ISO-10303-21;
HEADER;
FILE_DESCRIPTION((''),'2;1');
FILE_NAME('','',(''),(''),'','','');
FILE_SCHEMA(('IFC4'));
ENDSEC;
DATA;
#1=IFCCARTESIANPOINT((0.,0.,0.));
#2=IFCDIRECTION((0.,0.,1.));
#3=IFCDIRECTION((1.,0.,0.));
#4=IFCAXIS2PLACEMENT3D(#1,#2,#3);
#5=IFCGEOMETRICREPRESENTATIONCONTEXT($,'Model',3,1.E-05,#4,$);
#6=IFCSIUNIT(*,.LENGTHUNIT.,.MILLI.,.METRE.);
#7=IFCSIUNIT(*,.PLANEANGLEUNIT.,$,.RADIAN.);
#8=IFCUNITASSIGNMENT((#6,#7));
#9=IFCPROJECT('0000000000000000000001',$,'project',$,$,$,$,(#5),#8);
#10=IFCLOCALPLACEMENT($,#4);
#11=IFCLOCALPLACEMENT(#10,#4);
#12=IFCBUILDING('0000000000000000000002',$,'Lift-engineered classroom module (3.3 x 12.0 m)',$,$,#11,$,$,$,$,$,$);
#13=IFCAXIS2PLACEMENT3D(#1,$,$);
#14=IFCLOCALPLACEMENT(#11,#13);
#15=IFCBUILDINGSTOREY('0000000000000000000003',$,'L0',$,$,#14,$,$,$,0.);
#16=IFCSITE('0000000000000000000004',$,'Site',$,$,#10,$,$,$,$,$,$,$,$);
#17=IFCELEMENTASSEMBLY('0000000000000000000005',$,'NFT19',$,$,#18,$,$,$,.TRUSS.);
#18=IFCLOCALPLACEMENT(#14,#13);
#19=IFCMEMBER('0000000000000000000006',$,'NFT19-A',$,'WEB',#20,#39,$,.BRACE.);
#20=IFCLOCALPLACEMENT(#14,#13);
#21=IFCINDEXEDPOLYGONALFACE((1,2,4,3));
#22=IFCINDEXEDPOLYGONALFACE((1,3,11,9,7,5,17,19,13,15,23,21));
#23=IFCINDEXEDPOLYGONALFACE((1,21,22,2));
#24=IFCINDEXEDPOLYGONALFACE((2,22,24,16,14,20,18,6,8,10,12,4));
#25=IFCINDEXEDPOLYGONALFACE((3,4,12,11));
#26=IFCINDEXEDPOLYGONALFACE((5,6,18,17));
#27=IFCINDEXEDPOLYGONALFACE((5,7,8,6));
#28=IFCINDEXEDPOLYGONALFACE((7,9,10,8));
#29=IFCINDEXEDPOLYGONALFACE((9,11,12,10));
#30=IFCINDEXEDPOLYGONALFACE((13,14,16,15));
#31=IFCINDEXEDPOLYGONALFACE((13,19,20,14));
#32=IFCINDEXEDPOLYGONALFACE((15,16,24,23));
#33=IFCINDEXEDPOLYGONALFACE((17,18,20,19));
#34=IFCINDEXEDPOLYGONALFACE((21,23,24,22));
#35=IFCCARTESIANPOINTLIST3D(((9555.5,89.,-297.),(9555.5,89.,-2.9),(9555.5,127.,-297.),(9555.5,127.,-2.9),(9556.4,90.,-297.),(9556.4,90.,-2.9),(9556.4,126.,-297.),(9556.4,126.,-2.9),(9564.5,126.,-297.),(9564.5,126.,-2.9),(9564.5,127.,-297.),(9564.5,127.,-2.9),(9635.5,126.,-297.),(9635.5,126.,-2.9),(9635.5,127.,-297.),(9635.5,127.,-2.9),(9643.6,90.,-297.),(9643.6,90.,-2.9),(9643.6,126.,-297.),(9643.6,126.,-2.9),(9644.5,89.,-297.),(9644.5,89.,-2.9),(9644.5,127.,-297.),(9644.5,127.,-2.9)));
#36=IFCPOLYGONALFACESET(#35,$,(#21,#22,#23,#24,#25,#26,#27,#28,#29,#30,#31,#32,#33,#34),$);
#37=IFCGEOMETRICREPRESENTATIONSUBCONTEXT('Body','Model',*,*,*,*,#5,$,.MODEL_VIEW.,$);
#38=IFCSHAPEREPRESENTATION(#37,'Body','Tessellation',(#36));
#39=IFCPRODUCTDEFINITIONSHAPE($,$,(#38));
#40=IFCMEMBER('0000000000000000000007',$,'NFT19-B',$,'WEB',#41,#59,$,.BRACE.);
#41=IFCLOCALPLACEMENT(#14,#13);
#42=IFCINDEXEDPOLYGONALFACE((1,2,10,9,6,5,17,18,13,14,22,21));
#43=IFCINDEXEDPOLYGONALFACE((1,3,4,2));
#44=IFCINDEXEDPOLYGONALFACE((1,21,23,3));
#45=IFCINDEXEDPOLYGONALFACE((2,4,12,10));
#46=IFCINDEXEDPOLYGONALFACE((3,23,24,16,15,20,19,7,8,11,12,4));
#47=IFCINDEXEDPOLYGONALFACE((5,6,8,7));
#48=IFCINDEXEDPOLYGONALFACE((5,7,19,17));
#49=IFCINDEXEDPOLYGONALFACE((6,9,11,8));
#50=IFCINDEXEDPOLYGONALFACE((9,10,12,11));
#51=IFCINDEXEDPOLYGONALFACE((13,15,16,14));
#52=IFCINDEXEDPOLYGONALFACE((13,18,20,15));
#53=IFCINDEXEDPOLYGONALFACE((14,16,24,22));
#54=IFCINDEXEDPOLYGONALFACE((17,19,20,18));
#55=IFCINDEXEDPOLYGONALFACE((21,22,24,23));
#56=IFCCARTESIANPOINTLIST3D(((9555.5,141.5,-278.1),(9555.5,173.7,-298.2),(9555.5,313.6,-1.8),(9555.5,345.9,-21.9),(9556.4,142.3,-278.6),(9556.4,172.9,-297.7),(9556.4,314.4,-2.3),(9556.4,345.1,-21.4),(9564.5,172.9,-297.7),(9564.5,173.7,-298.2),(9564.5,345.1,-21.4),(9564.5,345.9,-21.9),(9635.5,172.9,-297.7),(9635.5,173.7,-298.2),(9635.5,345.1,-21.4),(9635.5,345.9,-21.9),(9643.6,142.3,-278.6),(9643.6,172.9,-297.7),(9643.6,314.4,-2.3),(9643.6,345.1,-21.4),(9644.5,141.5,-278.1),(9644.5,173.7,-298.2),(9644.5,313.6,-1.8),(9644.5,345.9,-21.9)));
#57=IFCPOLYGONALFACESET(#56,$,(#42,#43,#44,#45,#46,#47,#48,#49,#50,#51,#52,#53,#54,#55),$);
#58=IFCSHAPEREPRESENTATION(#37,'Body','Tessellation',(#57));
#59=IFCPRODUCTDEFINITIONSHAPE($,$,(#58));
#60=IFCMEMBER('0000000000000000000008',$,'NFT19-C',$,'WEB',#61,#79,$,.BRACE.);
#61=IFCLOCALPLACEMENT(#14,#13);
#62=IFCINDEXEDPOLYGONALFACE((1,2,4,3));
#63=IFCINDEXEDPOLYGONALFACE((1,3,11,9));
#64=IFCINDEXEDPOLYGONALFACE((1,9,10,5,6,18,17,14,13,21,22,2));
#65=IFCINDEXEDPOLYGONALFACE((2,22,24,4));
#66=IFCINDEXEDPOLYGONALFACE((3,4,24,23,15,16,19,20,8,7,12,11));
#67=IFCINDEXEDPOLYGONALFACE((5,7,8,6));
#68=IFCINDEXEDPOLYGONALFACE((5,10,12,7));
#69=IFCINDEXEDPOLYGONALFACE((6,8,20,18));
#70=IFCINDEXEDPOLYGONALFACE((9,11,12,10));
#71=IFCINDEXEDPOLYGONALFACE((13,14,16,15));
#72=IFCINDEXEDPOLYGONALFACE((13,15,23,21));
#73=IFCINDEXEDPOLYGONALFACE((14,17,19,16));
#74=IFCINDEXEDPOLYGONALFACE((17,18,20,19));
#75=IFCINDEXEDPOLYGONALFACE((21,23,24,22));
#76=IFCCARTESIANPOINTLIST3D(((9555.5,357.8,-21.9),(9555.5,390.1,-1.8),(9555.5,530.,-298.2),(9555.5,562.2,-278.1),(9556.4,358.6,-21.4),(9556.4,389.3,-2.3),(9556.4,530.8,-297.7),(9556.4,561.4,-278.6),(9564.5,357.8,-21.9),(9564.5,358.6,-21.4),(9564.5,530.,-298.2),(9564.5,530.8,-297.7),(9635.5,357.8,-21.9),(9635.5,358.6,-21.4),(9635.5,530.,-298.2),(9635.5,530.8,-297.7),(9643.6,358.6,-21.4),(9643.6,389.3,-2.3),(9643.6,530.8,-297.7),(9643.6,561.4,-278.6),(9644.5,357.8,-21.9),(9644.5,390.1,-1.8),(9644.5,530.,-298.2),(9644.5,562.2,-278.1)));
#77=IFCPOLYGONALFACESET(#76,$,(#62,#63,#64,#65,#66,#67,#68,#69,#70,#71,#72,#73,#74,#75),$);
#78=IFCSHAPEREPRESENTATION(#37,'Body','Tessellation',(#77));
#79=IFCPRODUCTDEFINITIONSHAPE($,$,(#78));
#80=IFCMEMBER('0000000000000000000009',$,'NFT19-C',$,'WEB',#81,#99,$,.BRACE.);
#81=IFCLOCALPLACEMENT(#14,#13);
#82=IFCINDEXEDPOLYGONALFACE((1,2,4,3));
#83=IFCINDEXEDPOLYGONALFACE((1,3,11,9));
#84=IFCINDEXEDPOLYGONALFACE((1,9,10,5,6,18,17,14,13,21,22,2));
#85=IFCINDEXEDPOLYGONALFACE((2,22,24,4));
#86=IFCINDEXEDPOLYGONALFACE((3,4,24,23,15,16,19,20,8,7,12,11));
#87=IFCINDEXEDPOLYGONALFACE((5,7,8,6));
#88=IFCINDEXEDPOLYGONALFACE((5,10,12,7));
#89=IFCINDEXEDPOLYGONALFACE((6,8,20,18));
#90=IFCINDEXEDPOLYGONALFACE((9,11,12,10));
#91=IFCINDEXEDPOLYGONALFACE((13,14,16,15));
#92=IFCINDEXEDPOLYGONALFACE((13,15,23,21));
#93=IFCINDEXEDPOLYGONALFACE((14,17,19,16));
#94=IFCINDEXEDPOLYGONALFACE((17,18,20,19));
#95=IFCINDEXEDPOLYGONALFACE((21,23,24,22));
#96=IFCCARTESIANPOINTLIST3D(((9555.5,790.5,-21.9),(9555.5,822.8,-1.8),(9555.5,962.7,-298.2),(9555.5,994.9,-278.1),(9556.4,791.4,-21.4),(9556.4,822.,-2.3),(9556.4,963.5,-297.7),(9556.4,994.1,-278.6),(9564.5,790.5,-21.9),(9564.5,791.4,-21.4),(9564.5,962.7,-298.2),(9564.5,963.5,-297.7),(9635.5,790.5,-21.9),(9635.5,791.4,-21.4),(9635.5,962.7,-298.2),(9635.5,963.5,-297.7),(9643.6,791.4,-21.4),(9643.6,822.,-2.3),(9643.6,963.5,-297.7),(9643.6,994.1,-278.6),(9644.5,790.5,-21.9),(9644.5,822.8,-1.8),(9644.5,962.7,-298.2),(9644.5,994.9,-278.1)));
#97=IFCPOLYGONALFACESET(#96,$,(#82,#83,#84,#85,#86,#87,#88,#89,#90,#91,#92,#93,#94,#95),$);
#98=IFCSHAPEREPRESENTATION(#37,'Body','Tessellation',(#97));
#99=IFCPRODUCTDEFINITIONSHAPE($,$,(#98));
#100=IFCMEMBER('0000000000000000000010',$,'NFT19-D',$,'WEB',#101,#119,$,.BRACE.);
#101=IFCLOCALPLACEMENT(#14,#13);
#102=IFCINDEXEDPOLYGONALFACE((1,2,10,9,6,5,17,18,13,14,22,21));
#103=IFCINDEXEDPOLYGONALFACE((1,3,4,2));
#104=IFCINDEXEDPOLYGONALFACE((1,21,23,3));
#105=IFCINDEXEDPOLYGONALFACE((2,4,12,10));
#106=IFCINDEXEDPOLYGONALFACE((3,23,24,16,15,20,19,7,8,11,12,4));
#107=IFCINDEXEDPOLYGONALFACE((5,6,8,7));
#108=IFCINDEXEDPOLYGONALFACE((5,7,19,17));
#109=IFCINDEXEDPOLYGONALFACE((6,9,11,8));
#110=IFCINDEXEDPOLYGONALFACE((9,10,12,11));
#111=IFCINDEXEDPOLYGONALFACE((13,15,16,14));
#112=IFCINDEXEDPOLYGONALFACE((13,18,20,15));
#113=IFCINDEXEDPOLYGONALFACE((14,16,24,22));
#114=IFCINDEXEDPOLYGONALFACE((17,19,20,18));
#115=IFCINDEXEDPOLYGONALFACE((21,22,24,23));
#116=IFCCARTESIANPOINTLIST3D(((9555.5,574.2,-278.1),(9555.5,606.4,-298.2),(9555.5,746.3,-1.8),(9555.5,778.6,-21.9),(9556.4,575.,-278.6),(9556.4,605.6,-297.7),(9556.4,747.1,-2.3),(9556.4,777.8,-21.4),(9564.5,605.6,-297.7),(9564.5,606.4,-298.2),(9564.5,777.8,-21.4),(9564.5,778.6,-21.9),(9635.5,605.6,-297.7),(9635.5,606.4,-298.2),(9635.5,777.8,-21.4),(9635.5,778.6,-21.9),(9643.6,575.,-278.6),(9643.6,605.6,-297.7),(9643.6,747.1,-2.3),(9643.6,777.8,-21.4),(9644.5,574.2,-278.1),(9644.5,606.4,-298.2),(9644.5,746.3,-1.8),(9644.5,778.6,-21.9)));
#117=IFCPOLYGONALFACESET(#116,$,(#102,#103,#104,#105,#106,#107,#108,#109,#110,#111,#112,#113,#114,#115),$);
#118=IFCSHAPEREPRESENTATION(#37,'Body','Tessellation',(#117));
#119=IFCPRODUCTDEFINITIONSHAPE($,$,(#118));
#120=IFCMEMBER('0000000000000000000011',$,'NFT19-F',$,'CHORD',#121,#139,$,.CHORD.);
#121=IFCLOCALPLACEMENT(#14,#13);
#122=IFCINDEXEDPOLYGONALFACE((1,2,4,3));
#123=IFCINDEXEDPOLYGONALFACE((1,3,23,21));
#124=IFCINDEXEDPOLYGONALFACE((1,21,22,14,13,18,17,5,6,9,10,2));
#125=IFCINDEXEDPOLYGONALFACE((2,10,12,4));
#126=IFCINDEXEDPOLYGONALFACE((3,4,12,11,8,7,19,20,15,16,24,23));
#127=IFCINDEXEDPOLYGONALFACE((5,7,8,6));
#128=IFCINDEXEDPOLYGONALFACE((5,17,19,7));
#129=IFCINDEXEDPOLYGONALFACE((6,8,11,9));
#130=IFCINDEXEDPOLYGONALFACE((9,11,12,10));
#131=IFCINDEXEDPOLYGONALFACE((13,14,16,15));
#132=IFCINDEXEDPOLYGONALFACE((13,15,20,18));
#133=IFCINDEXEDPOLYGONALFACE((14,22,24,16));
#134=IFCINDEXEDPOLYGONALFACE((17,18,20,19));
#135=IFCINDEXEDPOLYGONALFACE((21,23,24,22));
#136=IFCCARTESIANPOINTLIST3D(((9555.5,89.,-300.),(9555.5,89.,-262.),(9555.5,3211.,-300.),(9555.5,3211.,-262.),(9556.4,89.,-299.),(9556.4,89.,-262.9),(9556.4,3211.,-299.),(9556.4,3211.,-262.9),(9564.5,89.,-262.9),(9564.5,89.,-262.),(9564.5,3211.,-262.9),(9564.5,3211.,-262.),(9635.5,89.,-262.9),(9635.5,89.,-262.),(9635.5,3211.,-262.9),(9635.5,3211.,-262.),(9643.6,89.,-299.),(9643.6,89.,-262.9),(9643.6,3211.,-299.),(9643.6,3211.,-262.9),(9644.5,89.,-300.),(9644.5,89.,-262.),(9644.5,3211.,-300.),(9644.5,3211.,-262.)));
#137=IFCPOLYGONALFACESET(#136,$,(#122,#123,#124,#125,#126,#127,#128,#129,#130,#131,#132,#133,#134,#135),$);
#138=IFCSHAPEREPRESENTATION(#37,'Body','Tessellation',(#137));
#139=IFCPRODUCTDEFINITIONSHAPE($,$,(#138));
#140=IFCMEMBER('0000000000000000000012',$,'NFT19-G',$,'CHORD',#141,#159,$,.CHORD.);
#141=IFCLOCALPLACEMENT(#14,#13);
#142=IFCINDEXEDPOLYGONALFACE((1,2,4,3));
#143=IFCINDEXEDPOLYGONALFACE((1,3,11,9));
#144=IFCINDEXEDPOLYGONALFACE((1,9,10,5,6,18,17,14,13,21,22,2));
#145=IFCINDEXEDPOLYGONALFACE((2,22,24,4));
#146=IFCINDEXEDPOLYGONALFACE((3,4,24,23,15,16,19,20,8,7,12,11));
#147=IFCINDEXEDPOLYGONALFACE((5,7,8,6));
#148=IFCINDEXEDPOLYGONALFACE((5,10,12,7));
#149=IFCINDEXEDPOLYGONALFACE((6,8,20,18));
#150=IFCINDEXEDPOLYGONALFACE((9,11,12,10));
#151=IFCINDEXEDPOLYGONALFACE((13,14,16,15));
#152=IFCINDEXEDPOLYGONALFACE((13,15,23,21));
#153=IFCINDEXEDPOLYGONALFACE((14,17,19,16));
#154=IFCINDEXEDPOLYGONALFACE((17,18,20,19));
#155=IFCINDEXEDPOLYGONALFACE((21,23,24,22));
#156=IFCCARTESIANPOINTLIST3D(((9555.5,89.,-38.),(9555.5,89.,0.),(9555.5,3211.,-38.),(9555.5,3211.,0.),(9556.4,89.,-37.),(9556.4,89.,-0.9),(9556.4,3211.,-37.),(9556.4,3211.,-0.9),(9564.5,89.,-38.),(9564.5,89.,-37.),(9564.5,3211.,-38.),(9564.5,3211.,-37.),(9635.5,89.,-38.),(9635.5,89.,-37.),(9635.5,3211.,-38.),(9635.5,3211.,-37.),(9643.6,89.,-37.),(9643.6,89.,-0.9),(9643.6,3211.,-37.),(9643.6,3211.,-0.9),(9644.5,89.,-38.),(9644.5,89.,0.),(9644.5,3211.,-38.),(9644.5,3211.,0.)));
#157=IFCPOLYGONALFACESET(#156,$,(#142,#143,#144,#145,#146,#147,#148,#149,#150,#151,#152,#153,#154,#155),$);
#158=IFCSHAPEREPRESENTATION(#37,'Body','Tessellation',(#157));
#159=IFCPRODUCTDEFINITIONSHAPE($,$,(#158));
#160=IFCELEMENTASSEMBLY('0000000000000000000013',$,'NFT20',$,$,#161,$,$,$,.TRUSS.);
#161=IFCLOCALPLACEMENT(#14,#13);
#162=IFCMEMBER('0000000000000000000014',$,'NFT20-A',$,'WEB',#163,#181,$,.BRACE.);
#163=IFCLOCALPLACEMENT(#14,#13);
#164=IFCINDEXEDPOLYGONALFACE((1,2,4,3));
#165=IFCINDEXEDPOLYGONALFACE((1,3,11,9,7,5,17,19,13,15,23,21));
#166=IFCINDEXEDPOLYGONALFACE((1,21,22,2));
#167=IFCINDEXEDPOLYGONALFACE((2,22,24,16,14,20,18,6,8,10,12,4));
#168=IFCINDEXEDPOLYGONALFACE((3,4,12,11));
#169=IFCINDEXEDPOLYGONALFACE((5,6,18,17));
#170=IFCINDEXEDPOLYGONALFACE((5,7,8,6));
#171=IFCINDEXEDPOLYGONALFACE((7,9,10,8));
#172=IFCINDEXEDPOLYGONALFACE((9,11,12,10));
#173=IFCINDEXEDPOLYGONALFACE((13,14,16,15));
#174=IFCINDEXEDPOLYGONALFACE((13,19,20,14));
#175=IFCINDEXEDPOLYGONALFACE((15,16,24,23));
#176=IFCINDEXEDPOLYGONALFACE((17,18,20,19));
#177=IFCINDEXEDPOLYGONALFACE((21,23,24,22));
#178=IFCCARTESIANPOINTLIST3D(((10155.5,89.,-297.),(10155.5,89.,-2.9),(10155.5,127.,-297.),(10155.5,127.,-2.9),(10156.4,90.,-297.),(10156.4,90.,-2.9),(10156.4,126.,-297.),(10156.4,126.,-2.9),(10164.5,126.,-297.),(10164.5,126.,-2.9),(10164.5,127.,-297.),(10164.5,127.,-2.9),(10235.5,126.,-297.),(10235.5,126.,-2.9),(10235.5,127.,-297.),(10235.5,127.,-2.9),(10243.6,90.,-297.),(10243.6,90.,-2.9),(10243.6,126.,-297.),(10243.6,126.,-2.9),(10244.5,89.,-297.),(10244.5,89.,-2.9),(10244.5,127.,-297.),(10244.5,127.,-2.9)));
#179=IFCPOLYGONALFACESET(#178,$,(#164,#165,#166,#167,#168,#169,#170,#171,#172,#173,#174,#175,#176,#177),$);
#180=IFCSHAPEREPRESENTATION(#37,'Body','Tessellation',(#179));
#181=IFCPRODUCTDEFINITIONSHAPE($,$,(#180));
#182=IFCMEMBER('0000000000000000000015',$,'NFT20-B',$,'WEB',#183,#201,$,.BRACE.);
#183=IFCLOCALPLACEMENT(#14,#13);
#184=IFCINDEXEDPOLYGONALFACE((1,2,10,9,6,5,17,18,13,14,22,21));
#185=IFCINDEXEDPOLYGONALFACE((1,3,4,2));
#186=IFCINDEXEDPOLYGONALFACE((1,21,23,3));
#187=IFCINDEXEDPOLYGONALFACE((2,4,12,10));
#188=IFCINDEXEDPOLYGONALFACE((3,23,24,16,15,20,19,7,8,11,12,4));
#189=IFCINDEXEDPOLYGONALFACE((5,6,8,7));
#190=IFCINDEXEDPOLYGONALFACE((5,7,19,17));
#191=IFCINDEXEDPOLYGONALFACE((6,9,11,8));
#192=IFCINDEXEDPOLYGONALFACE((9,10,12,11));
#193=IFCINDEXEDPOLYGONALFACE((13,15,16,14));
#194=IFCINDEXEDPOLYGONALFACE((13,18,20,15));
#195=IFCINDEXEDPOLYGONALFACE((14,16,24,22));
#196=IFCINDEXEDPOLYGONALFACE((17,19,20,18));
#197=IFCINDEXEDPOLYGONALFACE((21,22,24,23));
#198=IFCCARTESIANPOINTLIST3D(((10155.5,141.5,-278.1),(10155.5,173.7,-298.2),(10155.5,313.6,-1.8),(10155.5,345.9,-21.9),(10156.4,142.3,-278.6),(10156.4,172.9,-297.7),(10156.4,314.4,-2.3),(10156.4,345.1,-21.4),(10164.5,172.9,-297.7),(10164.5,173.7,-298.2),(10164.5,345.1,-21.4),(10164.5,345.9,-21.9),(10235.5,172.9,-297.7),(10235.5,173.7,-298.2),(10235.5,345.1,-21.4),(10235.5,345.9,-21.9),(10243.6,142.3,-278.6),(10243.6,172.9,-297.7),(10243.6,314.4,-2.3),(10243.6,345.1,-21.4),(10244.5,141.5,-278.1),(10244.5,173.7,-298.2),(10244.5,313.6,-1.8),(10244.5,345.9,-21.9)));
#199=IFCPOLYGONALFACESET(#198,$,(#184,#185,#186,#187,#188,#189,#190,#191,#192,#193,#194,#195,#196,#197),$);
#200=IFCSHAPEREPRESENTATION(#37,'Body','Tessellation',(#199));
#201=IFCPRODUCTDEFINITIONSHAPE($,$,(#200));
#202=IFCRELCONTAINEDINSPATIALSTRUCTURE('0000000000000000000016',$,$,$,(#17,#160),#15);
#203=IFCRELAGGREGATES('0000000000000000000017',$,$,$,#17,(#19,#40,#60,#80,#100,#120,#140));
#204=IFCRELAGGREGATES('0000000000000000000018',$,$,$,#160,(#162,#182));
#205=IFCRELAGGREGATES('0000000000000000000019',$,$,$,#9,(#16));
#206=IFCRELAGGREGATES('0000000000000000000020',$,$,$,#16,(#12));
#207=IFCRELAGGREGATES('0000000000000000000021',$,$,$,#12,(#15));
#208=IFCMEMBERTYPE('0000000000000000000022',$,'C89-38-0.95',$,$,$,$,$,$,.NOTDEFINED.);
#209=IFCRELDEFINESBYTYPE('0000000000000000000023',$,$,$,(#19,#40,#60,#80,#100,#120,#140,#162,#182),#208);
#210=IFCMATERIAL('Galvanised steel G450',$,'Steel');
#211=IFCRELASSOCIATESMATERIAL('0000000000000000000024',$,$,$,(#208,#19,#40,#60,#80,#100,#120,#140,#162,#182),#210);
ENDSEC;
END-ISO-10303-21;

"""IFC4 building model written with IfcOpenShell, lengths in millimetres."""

from ifc_helpers import new_model, si_unit, frame, origin, origin_with_axes, origin_2d, place, context, subcontext, project, spatial, c_section, extrude, material, material_profile, profile_set, profile_usage, type_object, element, aggregate, save


model = new_model("IFC4")

# Units and contexts
model_context = context("Model", 3, precision=1e-05, world=origin_with_axes())
body_context = subcontext(model_context, "Body", "Model", "MODEL_VIEW")
ifc_project = project(units=[si_unit("LENGTHUNIT", "METRE", prefix="MILLI"), si_unit("PLANEANGLEUNIT", "RADIAN")], contexts=[model_context])

# Site, building, storey
site_placement = place(None, origin_with_axes())
site = spatial("IfcSite", under=ifc_project, at=site_placement, Name="Site")
building_placement = place(site_placement, origin_with_axes())
building = spatial("IfcBuilding", under=site, at=building_placement, Name="Lift-engineered classroom module (3.3 x 12.0 m)")
storey_placement = place(building_placement, origin())
storey = spatial("IfcBuildingStorey", under=building, at=storey_placement, Name="L0", Elevation=0.0)

# Element assemblies, members
assembly_1_placement = place(storey_placement, frame((9600.0, 89.0, -300.0)))
assembly_1 = element("IfcElementAssembly", 1, at=assembly_1_placement, inside=storey, Name="NFT19", PredefinedType="TRUSS")
ifc_material = material(Name="Galvanised steel G450", Category="Steel")
ifc_material_profile_1 = material_profile(ifc_material, c_section(Depth=89.0, Width=38.0, WallThickness=0.9, Girth=9.0, at=origin_2d()), Name="C89-38-0.95")
ifc_profile_set_1 = profile_set([ifc_material_profile_1], Name="C89-38-0.95")
ifc_profile_usage_1 = profile_usage(ifc_profile_set_1)
member_type_1 = type_object("IfcMemberType", Name="C89-38-0.95", PredefinedType="NOTDEFINED", material=ifc_profile_set_1)
member_1_placement = place(assembly_1_placement, frame((0.0, 19.0, 2.9), z_axis=(0.0, 0.0, 1.0), x_axis=(0.0, 1.0, 0.0)))
member_1 = element("IfcMember", 2, at=member_1_placement, type_object=member_type_1, material=ifc_profile_usage_1, Name="NFT19-A", ObjectType="WEB", PredefinedType="BRACE", context=body_context, shape_type="SweptSolid", body=[
    extrude(c_section(Depth=89.0, Width=38.0, WallThickness=0.9, Girth=9.0, at=origin_2d()), origin(), (0.0, 0.0, 1.0), 294.1),
])
member_2_placement = place(assembly_1_placement, frame((0.0, 68.6, 11.8), z_axis=(0.0, 0.528797, 0.848748), x_axis=(0.0, 0.848748, -0.528797)))
member_2 = element("IfcMember", 3, at=member_2_placement, type_object=member_type_1, material=ifc_profile_usage_1, Name="NFT19-B", ObjectType="WEB", PredefinedType="BRACE", context=body_context, shape_type="SweptSolid", body=[
    extrude(c_section(Depth=89.0, Width=38.0, WallThickness=0.9, Girth=9.0, at=origin_2d()), origin(), (0.0, 0.0, 1.0), 325.6),
])
member_3_placement = place(assembly_1_placement, frame((0.0, 457.1, 11.8), z_axis=(0.0, -0.528797, 0.848748), x_axis=(0.0, -0.848748, -0.528797)))
member_3 = element("IfcMember", 4, at=member_3_placement, type_object=member_type_1, material=ifc_profile_usage_1, Name="NFT19-C", ObjectType="WEB", PredefinedType="BRACE", context=body_context, shape_type="SweptSolid", body=[
    extrude(c_section(Depth=89.0, Width=38.0, WallThickness=0.9, Girth=9.0, at=origin_2d()), origin(), (0.0, 0.0, 1.0), 325.6),
])
member_4_placement = place(assembly_1_placement, frame((0.0, 889.8, 11.8), z_axis=(0.0, -0.528797, 0.848748), x_axis=(0.0, -0.848748, -0.528797)))
member_4 = element("IfcMember", 5, at=member_4_placement, type_object=member_type_1, material=ifc_profile_usage_1, Name="NFT19-C", ObjectType="WEB", PredefinedType="BRACE", context=body_context, shape_type="SweptSolid", body=[
    extrude(c_section(Depth=89.0, Width=38.0, WallThickness=0.9, Girth=9.0, at=origin_2d()), origin(), (0.0, 0.0, 1.0), 325.6),
])
member_5_placement = place(assembly_1_placement, frame((0.0, 501.3, 11.8), z_axis=(0.0, 0.528775, 0.848762), x_axis=(0.0, 0.848762, -0.528775)))
member_5 = element("IfcMember", 6, at=member_5_placement, type_object=member_type_1, material=ifc_profile_usage_1, Name="NFT19-D", ObjectType="WEB", PredefinedType="BRACE", context=body_context, shape_type="SweptSolid", body=[
    extrude(c_section(Depth=89.0, Width=38.0, WallThickness=0.9, Girth=9.0, at=origin_2d()), origin(), (0.0, 0.0, 1.0), 325.6),
])
member_6_placement = place(assembly_1_placement, frame((0.0, 0.0, 19.0), z_axis=(0.0, 1.0, 0.0), x_axis=(0.0, 0.0, 1.0)))
member_6 = element("IfcMember", 7, at=member_6_placement, type_object=member_type_1, material=ifc_profile_usage_1, Name="NFT19-F", ObjectType="CHORD", PredefinedType="CHORD", context=body_context, shape_type="SweptSolid", body=[
    extrude(c_section(Depth=89.0, Width=38.0, WallThickness=0.9, Girth=9.0, at=origin_2d()), origin(), (0.0, 0.0, 1.0), 3122.0),
])
member_7_placement = place(assembly_1_placement, frame((0.0, 0.0, 281.0), z_axis=(0.0, 1.0, 0.0), x_axis=(0.0, 0.0, -1.0)))
member_7 = element("IfcMember", 8, at=member_7_placement, type_object=member_type_1, material=ifc_profile_usage_1, Name="NFT19-G", ObjectType="CHORD", PredefinedType="CHORD", context=body_context, shape_type="SweptSolid", body=[
    extrude(c_section(Depth=89.0, Width=38.0, WallThickness=0.9, Girth=9.0, at=origin_2d()), origin(), (0.0, 0.0, 1.0), 3122.0),
])
aggregate(assembly_1, [member_1, member_2, member_3, member_4, member_5, member_6, member_7])
assembly_2_placement = place(storey_placement, frame((10200.0, 89.0, -300.0)))
assembly_2 = element("IfcElementAssembly", 9, at=assembly_2_placement, inside=storey, Name="NFT20", PredefinedType="TRUSS")
member_8_placement = place(assembly_2_placement, frame((0.0, 19.0, 2.9), z_axis=(0.0, 0.0, 1.0), x_axis=(0.0, 1.0, 0.0)))
member_8 = element("IfcMember", 10, at=member_8_placement, type_object=member_type_1, material=ifc_profile_usage_1, Name="NFT20-A", ObjectType="WEB", PredefinedType="BRACE", context=body_context, shape_type="SweptSolid", body=[
    extrude(c_section(Depth=89.0, Width=38.0, WallThickness=0.9, Girth=9.0, at=origin_2d()), origin(), (0.0, 0.0, 1.0), 294.1),
])
member_9_placement = place(assembly_2_placement, frame((0.0, 68.6, 11.8), z_axis=(0.0, 0.528797, 0.848748), x_axis=(0.0, 0.848748, -0.528797)))
member_9 = element("IfcMember", 11, at=member_9_placement, type_object=member_type_1, material=ifc_profile_usage_1, Name="NFT20-B", ObjectType="WEB", PredefinedType="BRACE", context=body_context, shape_type="SweptSolid", body=[
    extrude(c_section(Depth=89.0, Width=38.0, WallThickness=0.9, Girth=9.0, at=origin_2d()), origin(), (0.0, 0.0, 1.0), 325.6),
])
aggregate(assembly_2, [member_8, member_9])

save(model, "model.ifc")
